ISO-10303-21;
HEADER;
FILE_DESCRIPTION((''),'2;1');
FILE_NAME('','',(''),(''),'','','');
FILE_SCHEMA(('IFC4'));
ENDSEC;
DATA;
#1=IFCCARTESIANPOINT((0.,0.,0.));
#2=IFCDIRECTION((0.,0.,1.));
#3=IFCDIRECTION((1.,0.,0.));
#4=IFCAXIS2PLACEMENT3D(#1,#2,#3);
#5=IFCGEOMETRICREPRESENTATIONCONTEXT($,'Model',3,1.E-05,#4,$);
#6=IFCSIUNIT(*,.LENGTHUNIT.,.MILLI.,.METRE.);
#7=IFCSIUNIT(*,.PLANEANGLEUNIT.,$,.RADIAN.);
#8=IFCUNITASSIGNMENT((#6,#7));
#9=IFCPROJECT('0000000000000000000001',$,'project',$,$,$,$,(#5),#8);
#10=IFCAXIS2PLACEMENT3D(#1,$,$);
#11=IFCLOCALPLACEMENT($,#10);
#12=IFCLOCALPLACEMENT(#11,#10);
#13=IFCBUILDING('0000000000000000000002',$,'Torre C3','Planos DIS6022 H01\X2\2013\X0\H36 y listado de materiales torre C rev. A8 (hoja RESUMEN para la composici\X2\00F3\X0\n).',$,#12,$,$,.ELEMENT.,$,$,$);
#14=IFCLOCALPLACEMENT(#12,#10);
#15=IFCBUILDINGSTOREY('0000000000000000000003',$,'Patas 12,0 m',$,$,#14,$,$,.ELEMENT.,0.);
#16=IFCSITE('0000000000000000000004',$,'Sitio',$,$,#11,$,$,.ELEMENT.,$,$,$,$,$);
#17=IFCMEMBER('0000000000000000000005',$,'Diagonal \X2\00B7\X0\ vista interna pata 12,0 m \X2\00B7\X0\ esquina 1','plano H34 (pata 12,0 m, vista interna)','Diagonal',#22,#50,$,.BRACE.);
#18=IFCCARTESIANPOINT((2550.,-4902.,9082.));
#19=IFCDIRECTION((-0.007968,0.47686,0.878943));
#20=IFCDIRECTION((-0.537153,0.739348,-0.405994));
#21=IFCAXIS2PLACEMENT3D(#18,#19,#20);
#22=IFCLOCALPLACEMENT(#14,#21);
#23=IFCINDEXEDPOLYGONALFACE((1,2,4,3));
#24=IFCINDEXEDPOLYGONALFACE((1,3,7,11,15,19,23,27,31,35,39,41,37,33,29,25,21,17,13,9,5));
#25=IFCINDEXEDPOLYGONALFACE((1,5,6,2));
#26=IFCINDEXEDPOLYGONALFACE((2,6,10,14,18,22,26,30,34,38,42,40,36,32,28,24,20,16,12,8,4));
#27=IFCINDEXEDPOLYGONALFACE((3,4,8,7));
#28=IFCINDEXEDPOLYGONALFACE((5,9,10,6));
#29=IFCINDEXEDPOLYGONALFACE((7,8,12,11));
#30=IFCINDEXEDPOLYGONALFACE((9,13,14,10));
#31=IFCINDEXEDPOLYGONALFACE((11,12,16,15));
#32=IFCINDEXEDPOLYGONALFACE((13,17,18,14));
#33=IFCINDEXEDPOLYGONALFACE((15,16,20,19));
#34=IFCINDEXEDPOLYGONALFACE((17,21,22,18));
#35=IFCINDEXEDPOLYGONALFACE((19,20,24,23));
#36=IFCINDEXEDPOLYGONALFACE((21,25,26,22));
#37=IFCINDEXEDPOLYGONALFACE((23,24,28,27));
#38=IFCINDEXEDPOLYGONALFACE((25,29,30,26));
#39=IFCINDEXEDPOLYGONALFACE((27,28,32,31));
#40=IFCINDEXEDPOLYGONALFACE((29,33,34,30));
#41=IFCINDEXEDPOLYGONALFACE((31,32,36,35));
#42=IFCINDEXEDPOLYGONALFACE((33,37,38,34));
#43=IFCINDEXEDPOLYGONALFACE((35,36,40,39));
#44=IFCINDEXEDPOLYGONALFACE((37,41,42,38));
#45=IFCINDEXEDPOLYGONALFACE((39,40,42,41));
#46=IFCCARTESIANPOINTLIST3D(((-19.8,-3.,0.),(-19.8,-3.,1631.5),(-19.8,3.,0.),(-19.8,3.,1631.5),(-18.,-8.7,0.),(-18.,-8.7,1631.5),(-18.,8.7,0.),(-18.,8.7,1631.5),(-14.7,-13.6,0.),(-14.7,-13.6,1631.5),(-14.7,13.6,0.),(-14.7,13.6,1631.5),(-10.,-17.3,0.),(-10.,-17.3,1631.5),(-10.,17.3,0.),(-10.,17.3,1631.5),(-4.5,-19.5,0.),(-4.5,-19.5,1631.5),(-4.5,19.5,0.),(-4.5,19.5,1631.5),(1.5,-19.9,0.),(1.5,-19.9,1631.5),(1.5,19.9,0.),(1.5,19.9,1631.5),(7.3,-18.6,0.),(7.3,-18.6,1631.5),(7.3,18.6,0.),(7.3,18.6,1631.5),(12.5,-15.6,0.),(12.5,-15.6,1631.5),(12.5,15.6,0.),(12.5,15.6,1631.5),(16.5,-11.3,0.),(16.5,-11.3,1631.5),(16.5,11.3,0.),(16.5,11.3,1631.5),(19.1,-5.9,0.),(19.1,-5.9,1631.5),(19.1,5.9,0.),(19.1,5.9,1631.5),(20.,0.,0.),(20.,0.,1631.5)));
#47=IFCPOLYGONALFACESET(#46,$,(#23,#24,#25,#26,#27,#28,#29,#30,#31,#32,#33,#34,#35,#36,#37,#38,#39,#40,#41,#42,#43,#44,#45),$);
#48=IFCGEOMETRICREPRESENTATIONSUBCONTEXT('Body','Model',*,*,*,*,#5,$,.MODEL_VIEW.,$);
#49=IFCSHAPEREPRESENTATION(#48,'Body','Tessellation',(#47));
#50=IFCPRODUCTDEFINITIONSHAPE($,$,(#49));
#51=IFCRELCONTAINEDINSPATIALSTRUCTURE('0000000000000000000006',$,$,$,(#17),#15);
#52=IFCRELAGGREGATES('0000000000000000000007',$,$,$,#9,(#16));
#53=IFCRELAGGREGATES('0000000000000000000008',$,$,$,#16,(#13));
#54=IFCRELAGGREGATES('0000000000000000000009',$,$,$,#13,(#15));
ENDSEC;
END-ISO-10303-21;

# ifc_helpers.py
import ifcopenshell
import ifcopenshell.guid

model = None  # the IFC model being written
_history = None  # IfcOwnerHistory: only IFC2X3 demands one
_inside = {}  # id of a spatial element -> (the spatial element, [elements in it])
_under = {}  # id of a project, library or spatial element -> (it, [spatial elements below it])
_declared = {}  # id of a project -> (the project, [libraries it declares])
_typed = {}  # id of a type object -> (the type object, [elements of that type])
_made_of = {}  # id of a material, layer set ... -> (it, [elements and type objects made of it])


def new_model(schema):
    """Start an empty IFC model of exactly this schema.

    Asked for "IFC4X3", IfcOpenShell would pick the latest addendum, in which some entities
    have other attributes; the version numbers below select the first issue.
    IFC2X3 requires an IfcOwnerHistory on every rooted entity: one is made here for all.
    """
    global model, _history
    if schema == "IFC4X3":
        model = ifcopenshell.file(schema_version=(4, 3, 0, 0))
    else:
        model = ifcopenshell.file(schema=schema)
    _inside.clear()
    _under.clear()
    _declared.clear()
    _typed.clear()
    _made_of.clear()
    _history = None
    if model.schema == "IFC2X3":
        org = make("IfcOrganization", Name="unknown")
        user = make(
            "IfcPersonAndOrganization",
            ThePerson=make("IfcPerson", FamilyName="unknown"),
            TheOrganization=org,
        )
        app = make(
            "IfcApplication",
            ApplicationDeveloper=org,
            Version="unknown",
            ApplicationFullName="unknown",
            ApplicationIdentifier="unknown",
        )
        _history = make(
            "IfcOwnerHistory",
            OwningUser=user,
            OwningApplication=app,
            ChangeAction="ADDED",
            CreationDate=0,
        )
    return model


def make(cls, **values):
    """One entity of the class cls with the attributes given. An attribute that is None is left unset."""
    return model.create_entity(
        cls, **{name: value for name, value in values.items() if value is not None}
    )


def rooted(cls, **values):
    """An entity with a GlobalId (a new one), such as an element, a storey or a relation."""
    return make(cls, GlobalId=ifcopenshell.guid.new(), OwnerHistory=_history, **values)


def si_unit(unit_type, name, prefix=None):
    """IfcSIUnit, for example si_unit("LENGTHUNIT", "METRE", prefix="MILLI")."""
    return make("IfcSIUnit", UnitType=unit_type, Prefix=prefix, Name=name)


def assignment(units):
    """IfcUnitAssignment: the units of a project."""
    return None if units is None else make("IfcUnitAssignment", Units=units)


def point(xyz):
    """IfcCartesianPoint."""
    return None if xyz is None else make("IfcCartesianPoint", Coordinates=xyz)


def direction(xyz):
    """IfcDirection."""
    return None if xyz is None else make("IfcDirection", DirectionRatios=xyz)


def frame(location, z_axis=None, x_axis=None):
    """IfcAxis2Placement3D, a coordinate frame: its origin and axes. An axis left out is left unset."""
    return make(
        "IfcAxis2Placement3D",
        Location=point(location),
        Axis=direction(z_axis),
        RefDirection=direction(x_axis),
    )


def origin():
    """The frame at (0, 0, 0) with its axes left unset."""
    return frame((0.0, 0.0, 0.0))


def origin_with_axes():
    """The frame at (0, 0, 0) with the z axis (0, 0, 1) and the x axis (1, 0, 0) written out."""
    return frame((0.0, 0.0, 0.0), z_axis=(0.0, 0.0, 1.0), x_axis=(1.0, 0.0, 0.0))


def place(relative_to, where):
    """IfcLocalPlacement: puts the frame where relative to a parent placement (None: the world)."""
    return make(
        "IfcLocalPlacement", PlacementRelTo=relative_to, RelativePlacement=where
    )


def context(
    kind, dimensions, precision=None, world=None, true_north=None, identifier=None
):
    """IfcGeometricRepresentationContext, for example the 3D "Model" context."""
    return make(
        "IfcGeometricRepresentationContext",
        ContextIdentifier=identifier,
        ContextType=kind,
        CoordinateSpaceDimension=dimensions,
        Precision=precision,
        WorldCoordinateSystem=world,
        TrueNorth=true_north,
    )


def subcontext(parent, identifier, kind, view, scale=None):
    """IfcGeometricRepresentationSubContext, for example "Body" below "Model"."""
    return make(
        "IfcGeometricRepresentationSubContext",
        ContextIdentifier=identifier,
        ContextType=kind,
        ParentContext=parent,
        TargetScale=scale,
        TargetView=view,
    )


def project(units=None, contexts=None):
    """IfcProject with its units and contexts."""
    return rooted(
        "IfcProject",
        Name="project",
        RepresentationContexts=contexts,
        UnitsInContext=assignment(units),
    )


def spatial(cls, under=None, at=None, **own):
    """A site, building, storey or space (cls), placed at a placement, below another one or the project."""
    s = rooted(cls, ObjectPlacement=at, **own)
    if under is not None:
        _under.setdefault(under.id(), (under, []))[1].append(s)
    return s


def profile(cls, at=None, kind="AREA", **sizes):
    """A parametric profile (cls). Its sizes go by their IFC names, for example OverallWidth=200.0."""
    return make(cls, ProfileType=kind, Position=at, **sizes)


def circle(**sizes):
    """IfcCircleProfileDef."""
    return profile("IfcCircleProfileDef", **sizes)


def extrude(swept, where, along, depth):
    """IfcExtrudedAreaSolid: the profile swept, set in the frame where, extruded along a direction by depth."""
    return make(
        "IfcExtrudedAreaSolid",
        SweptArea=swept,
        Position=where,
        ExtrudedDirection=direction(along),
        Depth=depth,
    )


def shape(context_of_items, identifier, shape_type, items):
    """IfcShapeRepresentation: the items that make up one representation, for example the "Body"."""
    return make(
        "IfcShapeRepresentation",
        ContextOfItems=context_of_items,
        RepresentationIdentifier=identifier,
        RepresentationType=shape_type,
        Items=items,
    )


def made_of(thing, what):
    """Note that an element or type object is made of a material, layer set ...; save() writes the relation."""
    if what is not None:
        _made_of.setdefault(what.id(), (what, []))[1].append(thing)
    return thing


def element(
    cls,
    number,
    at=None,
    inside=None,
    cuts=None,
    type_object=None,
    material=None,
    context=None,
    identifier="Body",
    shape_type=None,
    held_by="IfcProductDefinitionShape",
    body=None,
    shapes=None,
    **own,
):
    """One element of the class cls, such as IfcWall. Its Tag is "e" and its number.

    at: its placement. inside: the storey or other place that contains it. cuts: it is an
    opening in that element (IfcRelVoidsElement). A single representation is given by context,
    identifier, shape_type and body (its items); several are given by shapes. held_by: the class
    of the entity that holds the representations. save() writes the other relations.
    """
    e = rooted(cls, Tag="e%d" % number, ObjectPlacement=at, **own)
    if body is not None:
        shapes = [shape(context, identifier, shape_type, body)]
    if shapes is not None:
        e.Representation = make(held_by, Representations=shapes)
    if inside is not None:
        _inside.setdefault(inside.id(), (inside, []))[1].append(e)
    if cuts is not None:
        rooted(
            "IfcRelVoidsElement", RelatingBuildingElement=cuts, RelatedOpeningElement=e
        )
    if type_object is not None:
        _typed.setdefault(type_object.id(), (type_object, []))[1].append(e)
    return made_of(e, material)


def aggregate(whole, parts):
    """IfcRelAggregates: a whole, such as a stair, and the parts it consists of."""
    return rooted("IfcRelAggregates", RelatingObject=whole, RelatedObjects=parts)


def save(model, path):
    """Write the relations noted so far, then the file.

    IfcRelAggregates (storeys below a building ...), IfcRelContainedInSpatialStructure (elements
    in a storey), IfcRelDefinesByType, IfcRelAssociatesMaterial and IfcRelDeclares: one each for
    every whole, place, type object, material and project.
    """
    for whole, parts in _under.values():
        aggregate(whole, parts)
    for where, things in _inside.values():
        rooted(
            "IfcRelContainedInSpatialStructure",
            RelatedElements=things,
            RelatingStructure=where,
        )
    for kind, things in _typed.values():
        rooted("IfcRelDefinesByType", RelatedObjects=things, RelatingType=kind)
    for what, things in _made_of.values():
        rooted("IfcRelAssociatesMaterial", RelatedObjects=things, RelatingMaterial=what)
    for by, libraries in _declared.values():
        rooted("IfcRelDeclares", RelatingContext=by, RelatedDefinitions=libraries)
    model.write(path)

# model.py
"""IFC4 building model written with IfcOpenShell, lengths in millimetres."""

from ifc_helpers import new_model, si_unit, frame, origin, origin_with_axes, place, context, subcontext, project, spatial, circle, extrude, element, save


model = new_model("IFC4")

# Units and contexts
model_context = context("Model", 3, precision=1e-05, world=origin_with_axes())
body_context = subcontext(model_context, "Body", "Model", "MODEL_VIEW")
ifc_project = project(units=[si_unit("LENGTHUNIT", "METRE", prefix="MILLI"), si_unit("PLANEANGLEUNIT", "RADIAN")], contexts=[model_context])

# Site, building, storey
site_placement = place(None, origin())
site = spatial("IfcSite", under=ifc_project, at=site_placement, Name="Sitio", CompositionType="ELEMENT")
building_placement = place(site_placement, origin())
building = spatial("IfcBuilding", under=site, at=building_placement, Name="Torre C3", Description="Planos DIS6022 H01–H36 y listado de materiales torre C rev. A8 (hoja RESUMEN para la composición).", CompositionType="ELEMENT")
storey_placement = place(building_placement, origin())
storey = spatial("IfcBuildingStorey", under=building, at=storey_placement, Name="Patas 12,0 m", CompositionType="ELEMENT", Elevation=0.0)

# Member
member_1_placement = place(storey_placement, frame((2550.0, -4902.0, 9082.0), z_axis=(-0.007968, 0.47686, 0.878943), x_axis=(-0.537153, 0.739348, -0.405994)))
element("IfcMember", 1, at=member_1_placement, inside=storey, Name="Diagonal · vista interna pata 12,0 m · esquina 1", Description="plano H34 (pata 12,0 m, vista interna)", ObjectType="Diagonal", PredefinedType="BRACE", context=body_context, shape_type="SweptSolid", body=[
    extrude(circle(Radius=20.0), None, (0.0, 0.0, 1.0), 1631.5),
])

save(model, "model.ifc")
